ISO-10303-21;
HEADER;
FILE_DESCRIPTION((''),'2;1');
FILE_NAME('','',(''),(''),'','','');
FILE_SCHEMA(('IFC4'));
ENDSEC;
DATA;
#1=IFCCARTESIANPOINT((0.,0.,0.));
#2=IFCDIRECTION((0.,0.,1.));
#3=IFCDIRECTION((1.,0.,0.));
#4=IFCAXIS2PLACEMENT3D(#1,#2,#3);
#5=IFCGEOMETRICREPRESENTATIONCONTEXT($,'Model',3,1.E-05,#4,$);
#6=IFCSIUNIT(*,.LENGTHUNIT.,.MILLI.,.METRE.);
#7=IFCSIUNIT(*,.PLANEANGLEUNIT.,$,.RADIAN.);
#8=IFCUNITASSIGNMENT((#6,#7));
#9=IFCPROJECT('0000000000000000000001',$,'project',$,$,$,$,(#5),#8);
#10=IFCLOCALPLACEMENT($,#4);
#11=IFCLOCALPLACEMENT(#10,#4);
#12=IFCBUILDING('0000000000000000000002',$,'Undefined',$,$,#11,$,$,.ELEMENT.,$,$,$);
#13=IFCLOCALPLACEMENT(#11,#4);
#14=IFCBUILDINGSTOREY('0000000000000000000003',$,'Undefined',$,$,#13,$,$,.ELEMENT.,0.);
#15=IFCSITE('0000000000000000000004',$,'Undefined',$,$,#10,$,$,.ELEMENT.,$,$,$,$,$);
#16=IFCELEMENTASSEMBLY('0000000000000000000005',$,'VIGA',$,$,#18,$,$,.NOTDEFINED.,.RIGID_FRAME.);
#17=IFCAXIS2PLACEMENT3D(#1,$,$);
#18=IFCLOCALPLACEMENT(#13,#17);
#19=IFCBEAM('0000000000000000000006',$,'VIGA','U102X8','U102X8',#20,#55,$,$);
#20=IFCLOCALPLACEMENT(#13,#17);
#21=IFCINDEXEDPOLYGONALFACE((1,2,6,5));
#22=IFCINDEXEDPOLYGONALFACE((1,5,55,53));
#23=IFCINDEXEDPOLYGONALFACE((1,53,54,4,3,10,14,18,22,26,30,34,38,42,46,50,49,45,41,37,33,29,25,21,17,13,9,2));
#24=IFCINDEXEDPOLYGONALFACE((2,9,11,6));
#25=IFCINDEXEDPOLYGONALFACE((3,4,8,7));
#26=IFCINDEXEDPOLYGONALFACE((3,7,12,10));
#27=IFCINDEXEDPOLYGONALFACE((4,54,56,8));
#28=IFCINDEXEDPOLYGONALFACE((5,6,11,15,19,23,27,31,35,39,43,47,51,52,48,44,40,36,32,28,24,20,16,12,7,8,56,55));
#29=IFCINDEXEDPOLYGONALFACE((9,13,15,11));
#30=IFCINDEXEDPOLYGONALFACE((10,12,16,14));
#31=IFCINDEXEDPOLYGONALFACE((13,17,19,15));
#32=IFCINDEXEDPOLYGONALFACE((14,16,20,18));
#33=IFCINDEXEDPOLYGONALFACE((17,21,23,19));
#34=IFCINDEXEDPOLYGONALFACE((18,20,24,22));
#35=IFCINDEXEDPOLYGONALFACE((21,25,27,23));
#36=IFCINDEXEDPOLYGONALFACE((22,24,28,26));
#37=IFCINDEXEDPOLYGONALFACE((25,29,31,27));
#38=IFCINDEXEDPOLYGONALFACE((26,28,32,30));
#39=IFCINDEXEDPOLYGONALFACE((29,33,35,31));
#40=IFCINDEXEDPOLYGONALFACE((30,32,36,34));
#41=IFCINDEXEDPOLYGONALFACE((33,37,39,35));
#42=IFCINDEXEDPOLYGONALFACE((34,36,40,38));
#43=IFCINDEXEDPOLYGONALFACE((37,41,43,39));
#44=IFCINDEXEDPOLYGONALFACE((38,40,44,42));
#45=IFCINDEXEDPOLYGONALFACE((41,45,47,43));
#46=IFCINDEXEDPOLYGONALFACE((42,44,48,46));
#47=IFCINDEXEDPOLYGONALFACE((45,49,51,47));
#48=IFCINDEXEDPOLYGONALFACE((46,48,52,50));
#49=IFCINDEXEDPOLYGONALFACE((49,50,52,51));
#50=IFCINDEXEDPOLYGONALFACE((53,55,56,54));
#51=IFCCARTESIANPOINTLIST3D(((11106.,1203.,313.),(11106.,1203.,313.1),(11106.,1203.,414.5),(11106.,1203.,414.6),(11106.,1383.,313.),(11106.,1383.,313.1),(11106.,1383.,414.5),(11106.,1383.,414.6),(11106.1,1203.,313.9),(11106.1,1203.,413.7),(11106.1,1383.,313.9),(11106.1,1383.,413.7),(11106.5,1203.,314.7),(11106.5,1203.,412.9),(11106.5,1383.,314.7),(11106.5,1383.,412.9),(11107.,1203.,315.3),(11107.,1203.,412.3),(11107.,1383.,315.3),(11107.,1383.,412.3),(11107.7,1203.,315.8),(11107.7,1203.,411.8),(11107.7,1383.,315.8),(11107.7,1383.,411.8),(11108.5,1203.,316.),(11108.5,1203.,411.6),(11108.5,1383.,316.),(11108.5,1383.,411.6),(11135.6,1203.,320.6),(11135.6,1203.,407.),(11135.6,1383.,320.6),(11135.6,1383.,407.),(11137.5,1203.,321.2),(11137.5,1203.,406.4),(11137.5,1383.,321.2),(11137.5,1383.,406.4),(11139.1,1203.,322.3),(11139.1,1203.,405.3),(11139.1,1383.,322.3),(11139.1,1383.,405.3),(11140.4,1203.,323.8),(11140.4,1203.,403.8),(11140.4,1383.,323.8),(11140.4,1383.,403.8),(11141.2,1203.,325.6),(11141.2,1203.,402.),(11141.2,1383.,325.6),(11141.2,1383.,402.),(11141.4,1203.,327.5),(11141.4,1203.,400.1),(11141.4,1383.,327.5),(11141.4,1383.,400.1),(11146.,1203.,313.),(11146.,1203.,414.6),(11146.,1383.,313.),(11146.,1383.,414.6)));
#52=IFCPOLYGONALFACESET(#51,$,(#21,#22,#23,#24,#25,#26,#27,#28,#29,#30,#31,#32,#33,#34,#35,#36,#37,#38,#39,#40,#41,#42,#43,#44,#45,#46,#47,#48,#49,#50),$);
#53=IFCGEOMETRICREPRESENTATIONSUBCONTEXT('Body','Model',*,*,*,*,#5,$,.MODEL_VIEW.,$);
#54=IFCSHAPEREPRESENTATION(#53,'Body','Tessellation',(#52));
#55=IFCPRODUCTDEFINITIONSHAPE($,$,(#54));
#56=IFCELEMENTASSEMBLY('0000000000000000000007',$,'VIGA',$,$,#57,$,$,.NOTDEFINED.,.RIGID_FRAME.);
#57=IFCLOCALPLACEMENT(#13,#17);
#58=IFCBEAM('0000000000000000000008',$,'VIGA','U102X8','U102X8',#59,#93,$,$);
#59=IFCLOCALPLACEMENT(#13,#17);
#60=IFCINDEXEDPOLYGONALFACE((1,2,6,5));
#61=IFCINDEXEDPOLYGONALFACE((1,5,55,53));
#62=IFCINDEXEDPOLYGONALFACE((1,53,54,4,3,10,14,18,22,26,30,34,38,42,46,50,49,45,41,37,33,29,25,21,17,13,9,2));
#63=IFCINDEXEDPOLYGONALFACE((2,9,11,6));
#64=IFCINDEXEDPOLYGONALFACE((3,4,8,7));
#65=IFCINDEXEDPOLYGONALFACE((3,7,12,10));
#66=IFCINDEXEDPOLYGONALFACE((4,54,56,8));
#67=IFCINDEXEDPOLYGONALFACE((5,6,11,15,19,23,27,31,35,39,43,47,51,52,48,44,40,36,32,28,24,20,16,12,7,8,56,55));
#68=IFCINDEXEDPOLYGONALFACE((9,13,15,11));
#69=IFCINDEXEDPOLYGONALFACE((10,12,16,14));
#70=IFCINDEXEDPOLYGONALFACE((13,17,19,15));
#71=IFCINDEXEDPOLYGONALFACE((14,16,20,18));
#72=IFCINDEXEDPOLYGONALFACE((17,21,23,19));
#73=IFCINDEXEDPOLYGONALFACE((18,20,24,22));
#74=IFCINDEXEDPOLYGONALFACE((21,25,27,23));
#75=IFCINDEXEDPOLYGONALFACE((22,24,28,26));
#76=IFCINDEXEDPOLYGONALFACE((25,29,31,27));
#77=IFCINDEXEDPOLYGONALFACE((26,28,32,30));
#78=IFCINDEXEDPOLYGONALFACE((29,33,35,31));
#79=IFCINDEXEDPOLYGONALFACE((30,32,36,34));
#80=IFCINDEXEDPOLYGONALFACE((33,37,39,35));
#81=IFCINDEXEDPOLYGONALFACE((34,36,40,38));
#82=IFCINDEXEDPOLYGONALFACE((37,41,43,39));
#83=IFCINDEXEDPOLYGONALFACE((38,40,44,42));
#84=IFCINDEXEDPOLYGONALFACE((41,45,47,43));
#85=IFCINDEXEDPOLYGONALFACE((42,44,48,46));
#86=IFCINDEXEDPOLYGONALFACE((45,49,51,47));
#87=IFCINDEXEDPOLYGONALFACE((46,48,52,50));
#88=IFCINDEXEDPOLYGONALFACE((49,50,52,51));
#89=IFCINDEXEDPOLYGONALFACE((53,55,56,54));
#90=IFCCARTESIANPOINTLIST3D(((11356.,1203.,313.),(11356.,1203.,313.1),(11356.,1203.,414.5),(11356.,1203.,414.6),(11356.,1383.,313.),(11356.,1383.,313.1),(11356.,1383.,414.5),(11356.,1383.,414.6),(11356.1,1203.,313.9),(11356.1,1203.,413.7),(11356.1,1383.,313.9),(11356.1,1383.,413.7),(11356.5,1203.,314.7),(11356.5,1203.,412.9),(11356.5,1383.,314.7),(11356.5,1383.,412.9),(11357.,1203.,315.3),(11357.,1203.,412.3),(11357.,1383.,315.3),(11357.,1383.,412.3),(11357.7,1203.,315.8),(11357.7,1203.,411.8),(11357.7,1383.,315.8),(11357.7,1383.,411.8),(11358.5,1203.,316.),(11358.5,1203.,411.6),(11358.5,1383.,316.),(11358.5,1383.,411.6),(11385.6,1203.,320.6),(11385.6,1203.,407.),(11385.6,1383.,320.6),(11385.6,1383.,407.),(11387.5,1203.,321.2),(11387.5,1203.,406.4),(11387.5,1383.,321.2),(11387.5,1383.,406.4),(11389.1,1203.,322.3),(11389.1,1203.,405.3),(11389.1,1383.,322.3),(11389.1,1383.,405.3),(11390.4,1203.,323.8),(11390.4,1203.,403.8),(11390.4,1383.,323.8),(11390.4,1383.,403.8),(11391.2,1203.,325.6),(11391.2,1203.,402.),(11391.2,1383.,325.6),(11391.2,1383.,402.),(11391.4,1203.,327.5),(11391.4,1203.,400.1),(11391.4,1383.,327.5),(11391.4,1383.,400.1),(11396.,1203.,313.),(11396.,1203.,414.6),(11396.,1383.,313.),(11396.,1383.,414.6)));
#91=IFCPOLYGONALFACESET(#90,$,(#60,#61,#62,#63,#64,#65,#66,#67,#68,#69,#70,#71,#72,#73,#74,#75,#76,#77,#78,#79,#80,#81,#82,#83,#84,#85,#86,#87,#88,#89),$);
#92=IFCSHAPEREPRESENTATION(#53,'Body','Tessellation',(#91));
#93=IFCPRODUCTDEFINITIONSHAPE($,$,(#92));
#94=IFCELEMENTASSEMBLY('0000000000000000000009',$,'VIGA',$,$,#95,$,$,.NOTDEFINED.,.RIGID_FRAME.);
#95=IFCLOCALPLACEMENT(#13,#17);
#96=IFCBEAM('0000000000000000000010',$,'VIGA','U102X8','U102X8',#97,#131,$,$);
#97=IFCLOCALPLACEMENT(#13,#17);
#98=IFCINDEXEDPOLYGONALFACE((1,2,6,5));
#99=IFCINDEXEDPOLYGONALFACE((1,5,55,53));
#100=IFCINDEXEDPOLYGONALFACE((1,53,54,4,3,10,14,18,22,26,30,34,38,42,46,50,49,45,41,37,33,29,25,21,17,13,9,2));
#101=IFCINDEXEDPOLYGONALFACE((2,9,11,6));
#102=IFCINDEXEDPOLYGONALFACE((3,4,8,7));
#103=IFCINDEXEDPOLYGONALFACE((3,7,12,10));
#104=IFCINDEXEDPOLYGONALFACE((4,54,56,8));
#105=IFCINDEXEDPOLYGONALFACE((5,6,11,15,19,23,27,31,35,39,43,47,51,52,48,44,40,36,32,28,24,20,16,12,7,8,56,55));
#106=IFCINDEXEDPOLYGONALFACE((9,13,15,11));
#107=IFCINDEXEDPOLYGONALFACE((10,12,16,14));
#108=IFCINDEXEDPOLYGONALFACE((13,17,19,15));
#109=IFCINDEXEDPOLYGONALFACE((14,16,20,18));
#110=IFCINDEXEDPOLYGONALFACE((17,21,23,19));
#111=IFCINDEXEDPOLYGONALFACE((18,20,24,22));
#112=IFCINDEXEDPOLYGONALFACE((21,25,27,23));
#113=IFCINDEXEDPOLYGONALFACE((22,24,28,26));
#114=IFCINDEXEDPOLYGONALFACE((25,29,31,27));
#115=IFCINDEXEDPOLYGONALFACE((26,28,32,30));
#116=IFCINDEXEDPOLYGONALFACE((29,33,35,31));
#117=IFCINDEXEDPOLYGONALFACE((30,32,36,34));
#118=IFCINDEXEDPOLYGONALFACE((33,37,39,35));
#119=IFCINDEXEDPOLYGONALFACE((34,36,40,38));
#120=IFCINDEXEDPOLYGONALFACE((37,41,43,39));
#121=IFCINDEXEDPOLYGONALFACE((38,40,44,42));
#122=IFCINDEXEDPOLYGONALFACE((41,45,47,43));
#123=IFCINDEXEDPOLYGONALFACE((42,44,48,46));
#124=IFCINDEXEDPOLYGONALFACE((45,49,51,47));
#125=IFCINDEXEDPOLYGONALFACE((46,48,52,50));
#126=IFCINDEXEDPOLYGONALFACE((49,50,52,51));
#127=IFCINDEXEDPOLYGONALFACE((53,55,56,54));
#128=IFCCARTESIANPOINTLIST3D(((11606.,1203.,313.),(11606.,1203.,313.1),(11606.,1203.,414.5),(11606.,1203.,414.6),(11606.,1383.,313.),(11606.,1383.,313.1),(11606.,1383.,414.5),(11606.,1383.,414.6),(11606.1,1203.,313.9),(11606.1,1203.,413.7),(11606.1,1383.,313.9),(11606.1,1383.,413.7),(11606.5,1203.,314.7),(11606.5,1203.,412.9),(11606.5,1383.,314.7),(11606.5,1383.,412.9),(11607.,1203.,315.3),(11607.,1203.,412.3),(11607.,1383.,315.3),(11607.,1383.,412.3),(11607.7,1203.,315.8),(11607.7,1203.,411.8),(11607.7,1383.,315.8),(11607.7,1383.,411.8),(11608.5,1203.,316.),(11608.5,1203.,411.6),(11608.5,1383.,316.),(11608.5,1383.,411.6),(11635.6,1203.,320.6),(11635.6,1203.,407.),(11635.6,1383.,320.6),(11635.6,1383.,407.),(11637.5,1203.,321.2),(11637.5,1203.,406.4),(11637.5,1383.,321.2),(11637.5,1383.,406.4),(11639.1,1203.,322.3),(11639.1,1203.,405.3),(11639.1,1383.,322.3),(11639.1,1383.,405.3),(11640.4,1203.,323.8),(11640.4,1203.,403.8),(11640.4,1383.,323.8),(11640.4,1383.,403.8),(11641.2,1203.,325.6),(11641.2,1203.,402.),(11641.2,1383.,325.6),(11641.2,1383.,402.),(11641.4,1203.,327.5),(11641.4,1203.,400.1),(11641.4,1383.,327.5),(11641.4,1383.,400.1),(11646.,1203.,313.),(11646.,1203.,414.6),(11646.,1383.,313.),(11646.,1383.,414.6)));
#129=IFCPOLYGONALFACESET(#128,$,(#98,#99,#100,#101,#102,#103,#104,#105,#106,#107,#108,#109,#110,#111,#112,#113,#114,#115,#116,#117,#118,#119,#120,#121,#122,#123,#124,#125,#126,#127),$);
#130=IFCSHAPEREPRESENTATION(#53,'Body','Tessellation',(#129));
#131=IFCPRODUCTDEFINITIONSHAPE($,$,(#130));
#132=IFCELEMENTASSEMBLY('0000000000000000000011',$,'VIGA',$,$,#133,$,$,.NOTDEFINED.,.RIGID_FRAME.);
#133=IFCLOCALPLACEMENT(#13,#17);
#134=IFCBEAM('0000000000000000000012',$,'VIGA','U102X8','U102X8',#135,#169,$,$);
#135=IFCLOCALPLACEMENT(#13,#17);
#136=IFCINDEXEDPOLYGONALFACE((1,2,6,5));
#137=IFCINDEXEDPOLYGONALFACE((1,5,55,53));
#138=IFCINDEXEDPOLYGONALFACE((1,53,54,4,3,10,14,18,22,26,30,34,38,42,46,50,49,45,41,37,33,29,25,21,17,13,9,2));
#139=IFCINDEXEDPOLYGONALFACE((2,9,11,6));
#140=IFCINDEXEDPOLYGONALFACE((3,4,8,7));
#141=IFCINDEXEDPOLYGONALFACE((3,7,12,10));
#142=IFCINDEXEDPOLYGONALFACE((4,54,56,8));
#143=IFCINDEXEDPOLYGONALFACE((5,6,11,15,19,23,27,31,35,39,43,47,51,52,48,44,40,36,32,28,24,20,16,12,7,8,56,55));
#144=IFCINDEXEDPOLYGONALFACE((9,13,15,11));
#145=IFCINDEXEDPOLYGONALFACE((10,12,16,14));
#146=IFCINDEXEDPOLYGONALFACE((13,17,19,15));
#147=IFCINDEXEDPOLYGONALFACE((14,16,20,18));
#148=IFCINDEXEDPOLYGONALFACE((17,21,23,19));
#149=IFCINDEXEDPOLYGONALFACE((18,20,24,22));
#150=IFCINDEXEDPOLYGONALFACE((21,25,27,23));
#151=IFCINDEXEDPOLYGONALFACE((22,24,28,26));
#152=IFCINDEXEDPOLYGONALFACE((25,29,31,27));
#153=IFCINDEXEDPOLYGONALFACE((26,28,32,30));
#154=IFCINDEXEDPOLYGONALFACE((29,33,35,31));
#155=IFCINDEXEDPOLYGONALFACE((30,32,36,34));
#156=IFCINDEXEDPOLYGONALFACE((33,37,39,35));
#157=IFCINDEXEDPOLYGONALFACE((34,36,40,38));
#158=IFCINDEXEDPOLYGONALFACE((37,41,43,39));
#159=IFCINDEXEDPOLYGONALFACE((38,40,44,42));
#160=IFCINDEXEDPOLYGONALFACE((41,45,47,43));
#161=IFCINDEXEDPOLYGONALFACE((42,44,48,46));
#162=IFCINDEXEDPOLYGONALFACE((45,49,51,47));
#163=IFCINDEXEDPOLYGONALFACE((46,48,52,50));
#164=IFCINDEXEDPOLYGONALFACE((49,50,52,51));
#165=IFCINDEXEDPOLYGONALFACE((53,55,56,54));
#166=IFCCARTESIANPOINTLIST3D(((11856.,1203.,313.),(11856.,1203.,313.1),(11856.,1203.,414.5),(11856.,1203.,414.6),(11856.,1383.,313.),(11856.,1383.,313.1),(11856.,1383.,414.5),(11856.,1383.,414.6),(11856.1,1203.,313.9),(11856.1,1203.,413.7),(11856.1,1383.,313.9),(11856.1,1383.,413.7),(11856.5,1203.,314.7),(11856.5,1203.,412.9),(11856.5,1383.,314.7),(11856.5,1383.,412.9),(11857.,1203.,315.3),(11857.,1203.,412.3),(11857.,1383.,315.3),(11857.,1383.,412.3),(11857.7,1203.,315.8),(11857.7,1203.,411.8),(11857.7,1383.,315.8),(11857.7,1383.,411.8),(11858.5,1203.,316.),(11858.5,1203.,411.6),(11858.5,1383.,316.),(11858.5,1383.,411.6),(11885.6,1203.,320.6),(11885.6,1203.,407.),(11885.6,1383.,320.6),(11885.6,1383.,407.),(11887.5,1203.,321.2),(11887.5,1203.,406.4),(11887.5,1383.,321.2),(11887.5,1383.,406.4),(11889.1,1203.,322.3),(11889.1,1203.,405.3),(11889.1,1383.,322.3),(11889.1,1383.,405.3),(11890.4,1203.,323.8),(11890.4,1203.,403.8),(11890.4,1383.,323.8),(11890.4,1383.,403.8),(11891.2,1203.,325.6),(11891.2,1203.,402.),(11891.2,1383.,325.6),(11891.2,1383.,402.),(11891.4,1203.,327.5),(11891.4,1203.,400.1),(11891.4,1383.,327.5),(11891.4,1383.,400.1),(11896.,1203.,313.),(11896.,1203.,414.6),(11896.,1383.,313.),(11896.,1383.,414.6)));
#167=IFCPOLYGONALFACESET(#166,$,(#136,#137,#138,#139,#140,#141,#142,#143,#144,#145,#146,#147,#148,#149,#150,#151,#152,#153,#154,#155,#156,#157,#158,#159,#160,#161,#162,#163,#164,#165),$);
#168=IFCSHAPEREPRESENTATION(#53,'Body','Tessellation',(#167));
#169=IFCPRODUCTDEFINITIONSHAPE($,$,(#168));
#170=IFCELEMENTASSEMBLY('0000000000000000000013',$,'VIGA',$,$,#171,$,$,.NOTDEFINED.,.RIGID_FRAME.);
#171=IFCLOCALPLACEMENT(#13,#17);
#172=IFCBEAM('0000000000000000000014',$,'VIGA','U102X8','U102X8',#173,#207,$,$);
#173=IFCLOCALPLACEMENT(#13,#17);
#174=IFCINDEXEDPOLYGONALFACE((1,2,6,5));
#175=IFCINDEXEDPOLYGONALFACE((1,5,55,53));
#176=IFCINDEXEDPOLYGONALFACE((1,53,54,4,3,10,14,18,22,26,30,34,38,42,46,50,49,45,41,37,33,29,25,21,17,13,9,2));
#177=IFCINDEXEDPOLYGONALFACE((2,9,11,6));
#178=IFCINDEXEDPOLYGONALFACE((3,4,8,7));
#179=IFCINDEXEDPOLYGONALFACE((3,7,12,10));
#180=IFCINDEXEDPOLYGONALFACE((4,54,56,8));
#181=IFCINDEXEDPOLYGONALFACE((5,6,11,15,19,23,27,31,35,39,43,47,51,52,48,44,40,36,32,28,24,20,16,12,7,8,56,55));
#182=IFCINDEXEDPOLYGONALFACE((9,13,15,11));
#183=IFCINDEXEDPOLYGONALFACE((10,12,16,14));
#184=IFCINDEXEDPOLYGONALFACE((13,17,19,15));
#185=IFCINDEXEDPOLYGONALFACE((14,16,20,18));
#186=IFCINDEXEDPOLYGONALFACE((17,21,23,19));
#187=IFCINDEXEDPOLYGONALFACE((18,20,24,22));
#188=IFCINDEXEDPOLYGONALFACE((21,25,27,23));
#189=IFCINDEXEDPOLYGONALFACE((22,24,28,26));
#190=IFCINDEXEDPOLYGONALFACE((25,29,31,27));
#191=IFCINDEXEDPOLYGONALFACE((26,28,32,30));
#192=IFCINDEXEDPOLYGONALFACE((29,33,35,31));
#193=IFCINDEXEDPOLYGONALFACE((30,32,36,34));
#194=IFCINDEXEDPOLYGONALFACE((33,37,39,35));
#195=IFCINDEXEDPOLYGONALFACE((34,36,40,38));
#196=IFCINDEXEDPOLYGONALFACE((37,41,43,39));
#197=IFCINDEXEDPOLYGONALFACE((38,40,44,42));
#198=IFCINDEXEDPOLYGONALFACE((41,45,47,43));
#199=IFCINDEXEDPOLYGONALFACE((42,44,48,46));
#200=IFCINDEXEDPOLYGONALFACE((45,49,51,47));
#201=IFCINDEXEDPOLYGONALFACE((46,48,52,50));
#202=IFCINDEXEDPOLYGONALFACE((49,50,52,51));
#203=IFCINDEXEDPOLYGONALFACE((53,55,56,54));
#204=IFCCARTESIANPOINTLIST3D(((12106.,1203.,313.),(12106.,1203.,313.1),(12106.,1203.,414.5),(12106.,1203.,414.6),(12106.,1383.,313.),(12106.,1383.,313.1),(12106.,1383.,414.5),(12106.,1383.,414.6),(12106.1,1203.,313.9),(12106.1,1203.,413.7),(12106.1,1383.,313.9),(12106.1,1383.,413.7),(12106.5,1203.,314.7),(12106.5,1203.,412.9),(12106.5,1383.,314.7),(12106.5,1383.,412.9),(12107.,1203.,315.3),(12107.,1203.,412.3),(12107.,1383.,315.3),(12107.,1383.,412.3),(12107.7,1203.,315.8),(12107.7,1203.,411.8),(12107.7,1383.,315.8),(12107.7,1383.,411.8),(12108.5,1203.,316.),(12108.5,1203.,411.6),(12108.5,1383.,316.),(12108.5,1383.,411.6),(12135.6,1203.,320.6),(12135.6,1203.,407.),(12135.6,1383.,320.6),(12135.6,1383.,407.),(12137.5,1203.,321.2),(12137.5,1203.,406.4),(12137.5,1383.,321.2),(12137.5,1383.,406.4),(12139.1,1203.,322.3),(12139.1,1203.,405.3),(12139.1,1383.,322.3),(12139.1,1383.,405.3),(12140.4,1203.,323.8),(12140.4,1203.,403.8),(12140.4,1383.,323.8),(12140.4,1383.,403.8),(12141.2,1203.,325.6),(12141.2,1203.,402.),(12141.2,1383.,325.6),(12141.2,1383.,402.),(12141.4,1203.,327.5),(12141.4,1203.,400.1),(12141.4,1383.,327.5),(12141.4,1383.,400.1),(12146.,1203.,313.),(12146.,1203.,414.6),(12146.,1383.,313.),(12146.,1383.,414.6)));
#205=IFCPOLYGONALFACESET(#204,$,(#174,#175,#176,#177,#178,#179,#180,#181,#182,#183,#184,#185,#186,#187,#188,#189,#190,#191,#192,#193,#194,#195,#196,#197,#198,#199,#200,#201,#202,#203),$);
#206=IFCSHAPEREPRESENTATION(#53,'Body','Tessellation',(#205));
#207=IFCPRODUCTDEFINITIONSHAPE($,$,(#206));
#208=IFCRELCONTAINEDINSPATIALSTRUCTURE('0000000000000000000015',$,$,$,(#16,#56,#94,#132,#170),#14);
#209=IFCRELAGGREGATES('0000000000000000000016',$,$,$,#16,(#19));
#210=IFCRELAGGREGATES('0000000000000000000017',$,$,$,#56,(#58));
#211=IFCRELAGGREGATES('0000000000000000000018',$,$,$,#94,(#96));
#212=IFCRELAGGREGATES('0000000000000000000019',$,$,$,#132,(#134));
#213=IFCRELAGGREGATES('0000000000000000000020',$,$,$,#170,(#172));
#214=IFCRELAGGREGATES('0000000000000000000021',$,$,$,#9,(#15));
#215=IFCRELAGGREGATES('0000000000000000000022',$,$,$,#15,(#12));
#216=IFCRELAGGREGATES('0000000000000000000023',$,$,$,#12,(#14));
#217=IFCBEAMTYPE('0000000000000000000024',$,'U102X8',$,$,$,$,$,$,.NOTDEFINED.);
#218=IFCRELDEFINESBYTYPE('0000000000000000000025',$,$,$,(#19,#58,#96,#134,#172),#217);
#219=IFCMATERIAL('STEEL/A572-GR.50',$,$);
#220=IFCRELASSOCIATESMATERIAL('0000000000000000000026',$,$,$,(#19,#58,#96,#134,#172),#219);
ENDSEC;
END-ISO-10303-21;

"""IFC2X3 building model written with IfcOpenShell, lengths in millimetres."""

from ifc_helpers import new_model, si_unit, frame, origin_with_axes, origin_2d_with_axis, place, context, subcontext, project, spatial, u_section, extrude, material, type_object, element, aggregate, save


model = new_model("IFC2X3")

# Units and contexts
model_context = context("Model", 3, precision=1e-05, world=origin_with_axes())
body_context = subcontext(model_context, "Body", "Model", "MODEL_VIEW")
ifc_project = project(units=[si_unit("LENGTHUNIT", "METRE", prefix="MILLI"), si_unit("PLANEANGLEUNIT", "RADIAN")], contexts=[model_context])

# Site, building, storey
site_placement = place(None, origin_with_axes())
site = spatial("IfcSite", under=ifc_project, at=site_placement, Name="Undefined", CompositionType="ELEMENT")
building_placement = place(site_placement, origin_with_axes())
building = spatial("IfcBuilding", under=site, at=building_placement, Name="Undefined", CompositionType="ELEMENT")
storey_placement = place(building_placement, origin_with_axes())
storey = spatial("IfcBuildingStorey", under=building, at=storey_placement, Name="Undefined", CompositionType="ELEMENT", Elevation=0.0)

# Element assemblies, beams
assembly_1_placement = place(storey_placement, origin_with_axes())
assembly_1 = element("IfcElementAssembly", 1, at=assembly_1_placement, inside=storey, Name="VIGA", AssemblyPlace="NOTDEFINED", PredefinedType="RIGID_FRAME")
ifc_material = material(Name="STEEL/A572-GR.50")
beam_type = type_object("IfcBeamType", Name="U102X8", PredefinedType="NOTDEFINED")
beam_1_placement = place(assembly_1_placement, frame((11126.0, 1383.0, 363.8), z_axis=(0.0, 0.0, 1.0), x_axis=(0.0, -1.0, 0.0)))
beam_1 = element("IfcBeam", 2, at=beam_1_placement, type_object=beam_type, material=ifc_material, Name="VIGA", Description="U102X8", ObjectType="U102X8", context=body_context, shape_type="SweptSolid", body=[
    extrude(u_section(Depth=101.6, FlangeWidth=40.0, WebThickness=4.6, FlangeThickness=6.0, FilletRadius=7.0, EdgeRadius=3.0, FlangeSlope=0.16839, at=origin_2d_with_axis()), frame((180.0, 0.0, 0.0), z_axis=(-1.0, 0.0, 0.0), x_axis=(0.0, -1.0, 0.0)), (0.0, 0.0, 1.0), 180.0),
])
aggregate(assembly_1, [beam_1])
assembly_2_placement = place(storey_placement, origin_with_axes())
assembly_2 = element("IfcElementAssembly", 3, at=assembly_2_placement, inside=storey, Name="VIGA", AssemblyPlace="NOTDEFINED", PredefinedType="RIGID_FRAME")
beam_2_placement = place(assembly_2_placement, frame((11376.0, 1383.0, 363.8), z_axis=(0.0, 0.0, 1.0), x_axis=(0.0, -1.0, 0.0)))
beam_2 = element("IfcBeam", 4, at=beam_2_placement, type_object=beam_type, material=ifc_material, Name="VIGA", Description="U102X8", ObjectType="U102X8", context=body_context, shape_type="SweptSolid", body=[
    extrude(u_section(Depth=101.6, FlangeWidth=40.0, WebThickness=4.6, FlangeThickness=6.0, FilletRadius=7.0, EdgeRadius=3.0, FlangeSlope=0.16839, at=origin_2d_with_axis()), frame((180.0, 0.0, 0.0), z_axis=(-1.0, 0.0, 0.0), x_axis=(0.0, -1.0, 0.0)), (0.0, 0.0, 1.0), 180.0),
])
aggregate(assembly_2, [beam_2])
assembly_3_placement = place(storey_placement, origin_with_axes())
assembly_3 = element("IfcElementAssembly", 5, at=assembly_3_placement, inside=storey, Name="VIGA", AssemblyPlace="NOTDEFINED", PredefinedType="RIGID_FRAME")
beam_3_placement = place(assembly_3_placement, frame((11626.0, 1383.0, 363.8), z_axis=(0.0, 0.0, 1.0), x_axis=(0.0, -1.0, 0.0)))
beam_3 = element("IfcBeam", 6, at=beam_3_placement, type_object=beam_type, material=ifc_material, Name="VIGA", Description="U102X8", ObjectType="U102X8", context=body_context, shape_type="SweptSolid", body=[
    extrude(u_section(Depth=101.6, FlangeWidth=40.0, WebThickness=4.6, FlangeThickness=6.0, FilletRadius=7.0, EdgeRadius=3.0, FlangeSlope=0.16839, at=origin_2d_with_axis()), frame((180.0, 0.0, 0.0), z_axis=(-1.0, 0.0, 0.0), x_axis=(0.0, -1.0, 0.0)), (0.0, 0.0, 1.0), 180.0),
])
aggregate(assembly_3, [beam_3])
assembly_4_placement = place(storey_placement, origin_with_axes())
assembly_4 = element("IfcElementAssembly", 7, at=assembly_4_placement, inside=storey, Name="VIGA", AssemblyPlace="NOTDEFINED", PredefinedType="RIGID_FRAME")
beam_4_placement = place(assembly_4_placement, frame((11876.0, 1383.0, 363.8), z_axis=(0.0, 0.0, 1.0), x_axis=(0.0, -1.0, 0.0)))
beam_4 = element("IfcBeam", 8, at=beam_4_placement, type_object=beam_type, material=ifc_material, Name="VIGA", Description="U102X8", ObjectType="U102X8", context=body_context, shape_type="SweptSolid", body=[
    extrude(u_section(Depth=101.6, FlangeWidth=40.0, WebThickness=4.6, FlangeThickness=6.0, FilletRadius=7.0, EdgeRadius=3.0, FlangeSlope=0.16839, at=origin_2d_with_axis()), frame((180.0, 0.0, 0.0), z_axis=(-1.0, 0.0, 0.0), x_axis=(0.0, -1.0, 0.0)), (0.0, 0.0, 1.0), 180.0),
])
aggregate(assembly_4, [beam_4])
assembly_5_placement = place(storey_placement, origin_with_axes())
assembly_5 = element("IfcElementAssembly", 9, at=assembly_5_placement, inside=storey, Name="VIGA", AssemblyPlace="NOTDEFINED", PredefinedType="RIGID_FRAME")
beam_5_placement = place(assembly_5_placement, frame((12126.0, 1383.0, 363.8), z_axis=(0.0, 0.0, 1.0), x_axis=(0.0, -1.0, 0.0)))
beam_5 = element("IfcBeam", 10, at=beam_5_placement, type_object=beam_type, material=ifc_material, Name="VIGA", Description="U102X8", ObjectType="U102X8", context=body_context, shape_type="SweptSolid", body=[
    extrude(u_section(Depth=101.6, FlangeWidth=40.0, WebThickness=4.6, FlangeThickness=6.0, FilletRadius=7.0, EdgeRadius=3.0, FlangeSlope=0.16839, at=origin_2d_with_axis()), frame((180.0, 0.0, 0.0), z_axis=(-1.0, 0.0, 0.0), x_axis=(0.0, -1.0, 0.0)), (0.0, 0.0, 1.0), 180.0),
])
aggregate(assembly_5, [beam_5])

save(model, "model.ifc")
